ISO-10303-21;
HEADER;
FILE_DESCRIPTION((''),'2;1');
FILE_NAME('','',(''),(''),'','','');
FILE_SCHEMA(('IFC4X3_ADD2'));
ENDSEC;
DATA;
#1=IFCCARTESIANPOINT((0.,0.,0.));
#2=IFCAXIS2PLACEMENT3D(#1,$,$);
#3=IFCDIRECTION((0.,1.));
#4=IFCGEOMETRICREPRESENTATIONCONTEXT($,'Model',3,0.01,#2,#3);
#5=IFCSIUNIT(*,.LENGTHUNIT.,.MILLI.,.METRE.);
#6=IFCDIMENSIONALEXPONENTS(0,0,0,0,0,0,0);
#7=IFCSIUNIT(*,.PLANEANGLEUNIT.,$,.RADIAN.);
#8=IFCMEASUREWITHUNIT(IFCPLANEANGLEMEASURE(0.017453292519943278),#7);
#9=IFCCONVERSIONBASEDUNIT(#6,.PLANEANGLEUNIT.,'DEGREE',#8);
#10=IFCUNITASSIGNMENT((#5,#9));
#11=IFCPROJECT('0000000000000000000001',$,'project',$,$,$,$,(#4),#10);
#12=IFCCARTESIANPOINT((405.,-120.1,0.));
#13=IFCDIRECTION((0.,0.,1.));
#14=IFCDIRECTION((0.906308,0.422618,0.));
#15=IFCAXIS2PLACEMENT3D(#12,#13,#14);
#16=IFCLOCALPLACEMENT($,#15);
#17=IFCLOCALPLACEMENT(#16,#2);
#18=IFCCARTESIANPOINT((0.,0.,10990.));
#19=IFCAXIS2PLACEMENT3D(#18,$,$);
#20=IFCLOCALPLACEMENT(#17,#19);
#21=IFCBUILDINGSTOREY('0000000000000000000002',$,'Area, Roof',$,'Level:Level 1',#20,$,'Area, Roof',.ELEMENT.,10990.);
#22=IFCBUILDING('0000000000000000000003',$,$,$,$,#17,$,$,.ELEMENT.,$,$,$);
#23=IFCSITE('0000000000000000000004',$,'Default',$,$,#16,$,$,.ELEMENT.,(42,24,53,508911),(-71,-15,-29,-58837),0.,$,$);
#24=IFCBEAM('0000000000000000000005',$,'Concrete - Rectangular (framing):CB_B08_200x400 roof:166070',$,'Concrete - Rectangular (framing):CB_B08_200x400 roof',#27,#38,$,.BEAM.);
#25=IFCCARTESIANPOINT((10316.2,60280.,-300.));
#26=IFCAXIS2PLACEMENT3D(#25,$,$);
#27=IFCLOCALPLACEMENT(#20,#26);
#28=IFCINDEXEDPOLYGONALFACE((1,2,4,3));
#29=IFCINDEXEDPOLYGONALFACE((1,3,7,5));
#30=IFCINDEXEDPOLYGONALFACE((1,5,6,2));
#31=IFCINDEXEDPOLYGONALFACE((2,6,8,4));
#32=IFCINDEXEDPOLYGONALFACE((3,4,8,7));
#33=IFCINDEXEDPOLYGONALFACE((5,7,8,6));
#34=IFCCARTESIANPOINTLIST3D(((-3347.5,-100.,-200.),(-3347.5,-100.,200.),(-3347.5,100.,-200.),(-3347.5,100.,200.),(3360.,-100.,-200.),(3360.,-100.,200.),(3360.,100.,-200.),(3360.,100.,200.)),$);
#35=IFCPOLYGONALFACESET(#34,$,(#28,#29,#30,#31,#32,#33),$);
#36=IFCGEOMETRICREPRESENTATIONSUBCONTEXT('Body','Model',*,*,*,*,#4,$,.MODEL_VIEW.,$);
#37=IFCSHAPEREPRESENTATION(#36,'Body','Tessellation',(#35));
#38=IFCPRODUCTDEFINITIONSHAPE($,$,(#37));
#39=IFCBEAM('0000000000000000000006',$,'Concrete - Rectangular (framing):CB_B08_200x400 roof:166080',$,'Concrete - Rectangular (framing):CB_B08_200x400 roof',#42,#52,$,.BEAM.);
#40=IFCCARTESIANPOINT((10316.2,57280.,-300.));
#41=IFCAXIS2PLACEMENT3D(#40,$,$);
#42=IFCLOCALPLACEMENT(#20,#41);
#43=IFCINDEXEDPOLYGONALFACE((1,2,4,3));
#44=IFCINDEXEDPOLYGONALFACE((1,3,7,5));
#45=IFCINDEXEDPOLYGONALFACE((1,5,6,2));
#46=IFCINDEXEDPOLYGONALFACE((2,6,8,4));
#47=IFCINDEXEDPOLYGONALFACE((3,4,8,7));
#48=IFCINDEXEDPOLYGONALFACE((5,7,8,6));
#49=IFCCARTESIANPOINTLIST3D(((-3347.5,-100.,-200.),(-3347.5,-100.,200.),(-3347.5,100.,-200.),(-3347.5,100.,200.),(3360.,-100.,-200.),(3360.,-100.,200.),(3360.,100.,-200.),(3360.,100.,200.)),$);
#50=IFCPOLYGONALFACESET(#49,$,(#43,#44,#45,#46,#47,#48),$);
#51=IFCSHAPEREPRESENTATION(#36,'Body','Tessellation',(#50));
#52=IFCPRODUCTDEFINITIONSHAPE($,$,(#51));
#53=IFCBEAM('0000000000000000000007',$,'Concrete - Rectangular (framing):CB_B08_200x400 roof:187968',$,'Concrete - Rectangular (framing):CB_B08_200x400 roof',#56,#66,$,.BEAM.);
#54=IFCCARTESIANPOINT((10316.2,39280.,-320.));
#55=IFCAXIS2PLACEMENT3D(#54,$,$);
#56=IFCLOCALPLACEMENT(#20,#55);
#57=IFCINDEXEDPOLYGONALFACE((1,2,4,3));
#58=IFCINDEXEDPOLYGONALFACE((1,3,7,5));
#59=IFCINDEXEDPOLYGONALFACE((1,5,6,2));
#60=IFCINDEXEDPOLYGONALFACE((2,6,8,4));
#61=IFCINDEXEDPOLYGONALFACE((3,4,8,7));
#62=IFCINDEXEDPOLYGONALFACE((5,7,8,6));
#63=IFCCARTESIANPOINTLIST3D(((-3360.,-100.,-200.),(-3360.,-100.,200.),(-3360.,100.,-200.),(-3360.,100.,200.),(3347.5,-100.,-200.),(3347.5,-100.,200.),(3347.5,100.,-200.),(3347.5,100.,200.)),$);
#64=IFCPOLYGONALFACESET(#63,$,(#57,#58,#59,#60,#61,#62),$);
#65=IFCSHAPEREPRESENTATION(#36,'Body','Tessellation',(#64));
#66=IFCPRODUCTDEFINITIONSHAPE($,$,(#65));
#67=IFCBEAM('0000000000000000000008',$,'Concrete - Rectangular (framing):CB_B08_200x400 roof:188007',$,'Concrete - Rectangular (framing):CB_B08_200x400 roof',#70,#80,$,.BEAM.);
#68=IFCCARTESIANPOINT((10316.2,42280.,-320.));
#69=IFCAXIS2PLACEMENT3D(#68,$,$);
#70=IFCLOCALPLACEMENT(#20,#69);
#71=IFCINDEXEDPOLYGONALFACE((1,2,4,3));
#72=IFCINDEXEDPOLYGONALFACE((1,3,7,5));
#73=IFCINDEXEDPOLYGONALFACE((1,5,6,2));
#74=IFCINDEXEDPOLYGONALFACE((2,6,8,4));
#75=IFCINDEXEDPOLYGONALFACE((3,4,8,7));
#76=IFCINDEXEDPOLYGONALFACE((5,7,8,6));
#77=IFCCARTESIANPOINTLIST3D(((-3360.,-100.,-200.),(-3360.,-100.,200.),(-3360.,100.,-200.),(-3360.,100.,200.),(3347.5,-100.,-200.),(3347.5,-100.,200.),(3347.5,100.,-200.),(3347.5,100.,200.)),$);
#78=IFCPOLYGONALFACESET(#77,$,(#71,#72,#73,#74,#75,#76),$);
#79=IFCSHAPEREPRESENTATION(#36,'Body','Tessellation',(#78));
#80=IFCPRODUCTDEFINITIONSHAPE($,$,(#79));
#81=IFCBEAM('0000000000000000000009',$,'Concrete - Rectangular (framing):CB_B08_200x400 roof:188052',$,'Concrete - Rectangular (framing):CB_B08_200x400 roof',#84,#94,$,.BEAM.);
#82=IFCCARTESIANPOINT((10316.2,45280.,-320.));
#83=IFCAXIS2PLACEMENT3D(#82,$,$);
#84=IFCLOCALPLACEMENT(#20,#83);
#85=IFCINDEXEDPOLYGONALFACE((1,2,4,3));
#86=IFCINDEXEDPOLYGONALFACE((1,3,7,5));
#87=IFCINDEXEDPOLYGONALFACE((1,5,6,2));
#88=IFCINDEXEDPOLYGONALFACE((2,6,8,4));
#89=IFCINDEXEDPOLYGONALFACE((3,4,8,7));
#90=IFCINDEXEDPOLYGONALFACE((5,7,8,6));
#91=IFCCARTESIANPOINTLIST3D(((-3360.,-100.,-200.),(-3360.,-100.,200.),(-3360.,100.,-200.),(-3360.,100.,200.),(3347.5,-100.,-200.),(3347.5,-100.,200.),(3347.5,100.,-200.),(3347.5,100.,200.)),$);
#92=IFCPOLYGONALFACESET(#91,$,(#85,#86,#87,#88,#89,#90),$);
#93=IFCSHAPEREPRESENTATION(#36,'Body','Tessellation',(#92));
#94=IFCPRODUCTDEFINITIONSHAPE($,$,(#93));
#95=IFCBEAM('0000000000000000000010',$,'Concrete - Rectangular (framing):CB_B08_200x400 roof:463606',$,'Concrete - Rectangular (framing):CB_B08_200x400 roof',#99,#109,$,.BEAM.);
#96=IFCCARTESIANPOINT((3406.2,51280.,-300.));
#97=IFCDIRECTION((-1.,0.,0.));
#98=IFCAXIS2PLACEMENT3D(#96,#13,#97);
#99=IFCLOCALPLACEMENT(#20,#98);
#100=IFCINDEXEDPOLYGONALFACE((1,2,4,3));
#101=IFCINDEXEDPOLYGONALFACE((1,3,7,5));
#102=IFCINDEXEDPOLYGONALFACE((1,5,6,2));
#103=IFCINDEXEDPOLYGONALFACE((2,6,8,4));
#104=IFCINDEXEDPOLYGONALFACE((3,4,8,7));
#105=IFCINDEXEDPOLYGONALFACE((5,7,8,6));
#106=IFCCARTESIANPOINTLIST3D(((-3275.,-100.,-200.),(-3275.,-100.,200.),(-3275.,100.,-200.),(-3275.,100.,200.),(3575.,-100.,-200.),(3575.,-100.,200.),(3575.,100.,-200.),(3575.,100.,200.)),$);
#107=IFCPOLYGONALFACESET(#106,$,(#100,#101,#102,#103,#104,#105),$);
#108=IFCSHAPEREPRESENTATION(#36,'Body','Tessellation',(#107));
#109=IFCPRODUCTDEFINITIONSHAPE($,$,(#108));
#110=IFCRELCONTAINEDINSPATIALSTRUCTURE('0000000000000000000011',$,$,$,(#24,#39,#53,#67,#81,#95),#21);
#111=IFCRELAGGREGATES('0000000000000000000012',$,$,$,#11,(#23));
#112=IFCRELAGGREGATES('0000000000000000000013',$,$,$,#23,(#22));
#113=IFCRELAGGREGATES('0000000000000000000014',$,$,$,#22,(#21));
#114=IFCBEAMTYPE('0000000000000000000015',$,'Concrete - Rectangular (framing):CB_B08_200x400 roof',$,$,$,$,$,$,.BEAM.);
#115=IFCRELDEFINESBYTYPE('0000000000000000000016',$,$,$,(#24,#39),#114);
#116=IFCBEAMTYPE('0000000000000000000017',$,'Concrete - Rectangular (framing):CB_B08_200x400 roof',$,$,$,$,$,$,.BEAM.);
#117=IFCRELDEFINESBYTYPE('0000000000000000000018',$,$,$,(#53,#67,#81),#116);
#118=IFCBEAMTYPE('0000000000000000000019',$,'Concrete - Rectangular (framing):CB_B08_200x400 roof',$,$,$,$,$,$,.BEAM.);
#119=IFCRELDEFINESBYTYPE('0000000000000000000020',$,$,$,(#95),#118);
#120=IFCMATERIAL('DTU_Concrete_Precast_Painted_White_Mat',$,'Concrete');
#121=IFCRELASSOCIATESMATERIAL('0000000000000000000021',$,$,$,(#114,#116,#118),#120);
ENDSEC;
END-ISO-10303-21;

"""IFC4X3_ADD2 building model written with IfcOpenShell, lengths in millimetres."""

from ifc_helpers import new_model, entity, si_unit, converted_unit, direction, frame, origin, origin_2d_with_axis, place, context, subcontext, project, spatial, rectangle, extrude, source, transform, mapped, material, material_profile, profile_set, type_object, type_shapes, element, save


model = new_model("IFC4X3_ADD2")

# Units and contexts
model_context = context("Model", 3, precision=0.01, world=origin(), true_north=direction((0.0, 1.0)))
body_context = subcontext(model_context, "Body", "Model", "MODEL_VIEW")
ifc_project = project(units=[si_unit("LENGTHUNIT", "METRE", prefix="MILLI"), converted_unit("PLANEANGLEUNIT", "DEGREE", entity("IfcPlaneAngleMeasure", 0.017453292519943278), si_unit("PLANEANGLEUNIT", "RADIAN"), dimensions=[0, 0, 0, 0, 0, 0, 0])], contexts=[model_context])

# Site, building, storey
site_placement = place(None, frame((405.0, -120.1, 0.0), z_axis=(0.0, 0.0, 1.0), x_axis=(0.906308, 0.422618, 0.0)))
site = spatial("IfcSite", under=ifc_project, at=site_placement, Name="Default", CompositionType="ELEMENT", RefLatitude=(42, 24, 53, 508911), RefLongitude=(-71, -15, -29, -58837), RefElevation=0.0)
building_placement = place(site_placement, origin())
building = spatial("IfcBuilding", under=site, at=building_placement, CompositionType="ELEMENT")
storey_placement = place(building_placement, frame((0.0, 0.0, 10990.0)))
storey = spatial("IfcBuildingStorey", under=building, at=storey_placement, Name="Area, Roof", ObjectType="Level:Level 1", LongName="Area, Roof", CompositionType="ELEMENT", Elevation=10990.0)

# Beams
ifc_material_1 = material(Name="DTU_Concrete_Precast_Painted_White_Mat", Category="Concrete")
ifc_material_profile_1 = material_profile(ifc_material_1, rectangle(XDim=7137.5, YDim=200.0, at=origin_2d_with_axis()), Name="CB_B08_200x400 roof")
ifc_profile_set_1 = profile_set([ifc_material_profile_1], Name="CB_B08_200x400 roof")
beam_type_1 = type_object("IfcBeamType", Name="Concrete - Rectangular (framing):CB_B08_200x400 roof", PredefinedType="BEAM", material=ifc_profile_set_1)
shared_shape_1 = source(origin(), body_context, "Body", "SweptSolid", [
    extrude(rectangle(XDim=6707.5, YDim=200.0, at=origin_2d_with_axis()), frame((6.3, 0.0, -200.0), z_axis=(0.0, 0.0, 1.0), x_axis=(-1.0, 0.0, 0.0)), (0.0, 0.0, 1.0), 400.0),
])
type_shapes(beam_type_1, [shared_shape_1])
for number, where, name in (
    (1, (10316.2, 60280.0, -300.0), "Concrete - Rectangular (framing):CB_B08_200x400 roof:166070"),
    (2, (10316.2, 57280.0, -300.0), "Concrete - Rectangular (framing):CB_B08_200x400 roof:166080"),
):
    element("IfcBeam", number, at=place(storey_placement, frame(where)), inside=storey, type_object=beam_type_1, Name=name, ObjectType="Concrete - Rectangular (framing):CB_B08_200x400 roof", PredefinedType="BEAM", context=body_context, shape_type="MappedRepresentation", body=[
        mapped(shared_shape_1, transform((0.0, 0.0, 0.0), scale=1.0)),
    ])
beam_type_2 = type_object("IfcBeamType", Name="Concrete - Rectangular (framing):CB_B08_200x400 roof", PredefinedType="BEAM", material=ifc_profile_set_1)
shared_shape_2 = source(origin(), body_context, "Body", "SweptSolid", [
    extrude(rectangle(XDim=6707.5, YDim=200.0, at=origin_2d_with_axis()), frame((-6.3, 0.0, -200.0), z_axis=(0.0, 0.0, 1.0), x_axis=(-1.0, 0.0, 0.0)), (0.0, 0.0, 1.0), 400.0),
])
type_shapes(beam_type_2, [shared_shape_2])
for number, where, name in (
    (3, (10316.2, 39280.0, -320.0), "Concrete - Rectangular (framing):CB_B08_200x400 roof:187968"),
    (4, (10316.2, 42280.0, -320.0), "Concrete - Rectangular (framing):CB_B08_200x400 roof:188007"),
    (5, (10316.2, 45280.0, -320.0), "Concrete - Rectangular (framing):CB_B08_200x400 roof:188052"),
):
    element("IfcBeam", number, at=place(storey_placement, frame(where)), inside=storey, type_object=beam_type_2, Name=name, ObjectType="Concrete - Rectangular (framing):CB_B08_200x400 roof", PredefinedType="BEAM", context=body_context, shape_type="MappedRepresentation", body=[
        mapped(shared_shape_2, transform((0.0, 0.0, 0.0), scale=1.0)),
    ])
beam_type_3 = type_object("IfcBeamType", Name="Concrete - Rectangular (framing):CB_B08_200x400 roof", PredefinedType="BEAM", material=ifc_profile_set_1)
shared_shape_3 = source(origin(), body_context, "Body", "SweptSolid", [
    extrude(rectangle(XDim=6850.0, YDim=200.0, at=origin_2d_with_axis()), frame((150.0, 0.0, -200.0), z_axis=(0.0, 0.0, 1.0), x_axis=(-1.0, 0.0, 0.0)), (0.0, 0.0, 1.0), 400.0),
])
type_shapes(beam_type_3, [shared_shape_3])
beam_1_placement = place(storey_placement, frame((3406.2, 51280.0, -300.0), z_axis=(0.0, 0.0, 1.0), x_axis=(-1.0, 0.0, 0.0)))
element("IfcBeam", 6, at=beam_1_placement, inside=storey, type_object=beam_type_3, Name="Concrete - Rectangular (framing):CB_B08_200x400 roof:463606", ObjectType="Concrete - Rectangular (framing):CB_B08_200x400 roof", PredefinedType="BEAM", context=body_context, shape_type="MappedRepresentation", body=[
    mapped(shared_shape_3, transform((0.0, 0.0, 0.0), scale=1.0)),
])

save(model, "model.ifc")
